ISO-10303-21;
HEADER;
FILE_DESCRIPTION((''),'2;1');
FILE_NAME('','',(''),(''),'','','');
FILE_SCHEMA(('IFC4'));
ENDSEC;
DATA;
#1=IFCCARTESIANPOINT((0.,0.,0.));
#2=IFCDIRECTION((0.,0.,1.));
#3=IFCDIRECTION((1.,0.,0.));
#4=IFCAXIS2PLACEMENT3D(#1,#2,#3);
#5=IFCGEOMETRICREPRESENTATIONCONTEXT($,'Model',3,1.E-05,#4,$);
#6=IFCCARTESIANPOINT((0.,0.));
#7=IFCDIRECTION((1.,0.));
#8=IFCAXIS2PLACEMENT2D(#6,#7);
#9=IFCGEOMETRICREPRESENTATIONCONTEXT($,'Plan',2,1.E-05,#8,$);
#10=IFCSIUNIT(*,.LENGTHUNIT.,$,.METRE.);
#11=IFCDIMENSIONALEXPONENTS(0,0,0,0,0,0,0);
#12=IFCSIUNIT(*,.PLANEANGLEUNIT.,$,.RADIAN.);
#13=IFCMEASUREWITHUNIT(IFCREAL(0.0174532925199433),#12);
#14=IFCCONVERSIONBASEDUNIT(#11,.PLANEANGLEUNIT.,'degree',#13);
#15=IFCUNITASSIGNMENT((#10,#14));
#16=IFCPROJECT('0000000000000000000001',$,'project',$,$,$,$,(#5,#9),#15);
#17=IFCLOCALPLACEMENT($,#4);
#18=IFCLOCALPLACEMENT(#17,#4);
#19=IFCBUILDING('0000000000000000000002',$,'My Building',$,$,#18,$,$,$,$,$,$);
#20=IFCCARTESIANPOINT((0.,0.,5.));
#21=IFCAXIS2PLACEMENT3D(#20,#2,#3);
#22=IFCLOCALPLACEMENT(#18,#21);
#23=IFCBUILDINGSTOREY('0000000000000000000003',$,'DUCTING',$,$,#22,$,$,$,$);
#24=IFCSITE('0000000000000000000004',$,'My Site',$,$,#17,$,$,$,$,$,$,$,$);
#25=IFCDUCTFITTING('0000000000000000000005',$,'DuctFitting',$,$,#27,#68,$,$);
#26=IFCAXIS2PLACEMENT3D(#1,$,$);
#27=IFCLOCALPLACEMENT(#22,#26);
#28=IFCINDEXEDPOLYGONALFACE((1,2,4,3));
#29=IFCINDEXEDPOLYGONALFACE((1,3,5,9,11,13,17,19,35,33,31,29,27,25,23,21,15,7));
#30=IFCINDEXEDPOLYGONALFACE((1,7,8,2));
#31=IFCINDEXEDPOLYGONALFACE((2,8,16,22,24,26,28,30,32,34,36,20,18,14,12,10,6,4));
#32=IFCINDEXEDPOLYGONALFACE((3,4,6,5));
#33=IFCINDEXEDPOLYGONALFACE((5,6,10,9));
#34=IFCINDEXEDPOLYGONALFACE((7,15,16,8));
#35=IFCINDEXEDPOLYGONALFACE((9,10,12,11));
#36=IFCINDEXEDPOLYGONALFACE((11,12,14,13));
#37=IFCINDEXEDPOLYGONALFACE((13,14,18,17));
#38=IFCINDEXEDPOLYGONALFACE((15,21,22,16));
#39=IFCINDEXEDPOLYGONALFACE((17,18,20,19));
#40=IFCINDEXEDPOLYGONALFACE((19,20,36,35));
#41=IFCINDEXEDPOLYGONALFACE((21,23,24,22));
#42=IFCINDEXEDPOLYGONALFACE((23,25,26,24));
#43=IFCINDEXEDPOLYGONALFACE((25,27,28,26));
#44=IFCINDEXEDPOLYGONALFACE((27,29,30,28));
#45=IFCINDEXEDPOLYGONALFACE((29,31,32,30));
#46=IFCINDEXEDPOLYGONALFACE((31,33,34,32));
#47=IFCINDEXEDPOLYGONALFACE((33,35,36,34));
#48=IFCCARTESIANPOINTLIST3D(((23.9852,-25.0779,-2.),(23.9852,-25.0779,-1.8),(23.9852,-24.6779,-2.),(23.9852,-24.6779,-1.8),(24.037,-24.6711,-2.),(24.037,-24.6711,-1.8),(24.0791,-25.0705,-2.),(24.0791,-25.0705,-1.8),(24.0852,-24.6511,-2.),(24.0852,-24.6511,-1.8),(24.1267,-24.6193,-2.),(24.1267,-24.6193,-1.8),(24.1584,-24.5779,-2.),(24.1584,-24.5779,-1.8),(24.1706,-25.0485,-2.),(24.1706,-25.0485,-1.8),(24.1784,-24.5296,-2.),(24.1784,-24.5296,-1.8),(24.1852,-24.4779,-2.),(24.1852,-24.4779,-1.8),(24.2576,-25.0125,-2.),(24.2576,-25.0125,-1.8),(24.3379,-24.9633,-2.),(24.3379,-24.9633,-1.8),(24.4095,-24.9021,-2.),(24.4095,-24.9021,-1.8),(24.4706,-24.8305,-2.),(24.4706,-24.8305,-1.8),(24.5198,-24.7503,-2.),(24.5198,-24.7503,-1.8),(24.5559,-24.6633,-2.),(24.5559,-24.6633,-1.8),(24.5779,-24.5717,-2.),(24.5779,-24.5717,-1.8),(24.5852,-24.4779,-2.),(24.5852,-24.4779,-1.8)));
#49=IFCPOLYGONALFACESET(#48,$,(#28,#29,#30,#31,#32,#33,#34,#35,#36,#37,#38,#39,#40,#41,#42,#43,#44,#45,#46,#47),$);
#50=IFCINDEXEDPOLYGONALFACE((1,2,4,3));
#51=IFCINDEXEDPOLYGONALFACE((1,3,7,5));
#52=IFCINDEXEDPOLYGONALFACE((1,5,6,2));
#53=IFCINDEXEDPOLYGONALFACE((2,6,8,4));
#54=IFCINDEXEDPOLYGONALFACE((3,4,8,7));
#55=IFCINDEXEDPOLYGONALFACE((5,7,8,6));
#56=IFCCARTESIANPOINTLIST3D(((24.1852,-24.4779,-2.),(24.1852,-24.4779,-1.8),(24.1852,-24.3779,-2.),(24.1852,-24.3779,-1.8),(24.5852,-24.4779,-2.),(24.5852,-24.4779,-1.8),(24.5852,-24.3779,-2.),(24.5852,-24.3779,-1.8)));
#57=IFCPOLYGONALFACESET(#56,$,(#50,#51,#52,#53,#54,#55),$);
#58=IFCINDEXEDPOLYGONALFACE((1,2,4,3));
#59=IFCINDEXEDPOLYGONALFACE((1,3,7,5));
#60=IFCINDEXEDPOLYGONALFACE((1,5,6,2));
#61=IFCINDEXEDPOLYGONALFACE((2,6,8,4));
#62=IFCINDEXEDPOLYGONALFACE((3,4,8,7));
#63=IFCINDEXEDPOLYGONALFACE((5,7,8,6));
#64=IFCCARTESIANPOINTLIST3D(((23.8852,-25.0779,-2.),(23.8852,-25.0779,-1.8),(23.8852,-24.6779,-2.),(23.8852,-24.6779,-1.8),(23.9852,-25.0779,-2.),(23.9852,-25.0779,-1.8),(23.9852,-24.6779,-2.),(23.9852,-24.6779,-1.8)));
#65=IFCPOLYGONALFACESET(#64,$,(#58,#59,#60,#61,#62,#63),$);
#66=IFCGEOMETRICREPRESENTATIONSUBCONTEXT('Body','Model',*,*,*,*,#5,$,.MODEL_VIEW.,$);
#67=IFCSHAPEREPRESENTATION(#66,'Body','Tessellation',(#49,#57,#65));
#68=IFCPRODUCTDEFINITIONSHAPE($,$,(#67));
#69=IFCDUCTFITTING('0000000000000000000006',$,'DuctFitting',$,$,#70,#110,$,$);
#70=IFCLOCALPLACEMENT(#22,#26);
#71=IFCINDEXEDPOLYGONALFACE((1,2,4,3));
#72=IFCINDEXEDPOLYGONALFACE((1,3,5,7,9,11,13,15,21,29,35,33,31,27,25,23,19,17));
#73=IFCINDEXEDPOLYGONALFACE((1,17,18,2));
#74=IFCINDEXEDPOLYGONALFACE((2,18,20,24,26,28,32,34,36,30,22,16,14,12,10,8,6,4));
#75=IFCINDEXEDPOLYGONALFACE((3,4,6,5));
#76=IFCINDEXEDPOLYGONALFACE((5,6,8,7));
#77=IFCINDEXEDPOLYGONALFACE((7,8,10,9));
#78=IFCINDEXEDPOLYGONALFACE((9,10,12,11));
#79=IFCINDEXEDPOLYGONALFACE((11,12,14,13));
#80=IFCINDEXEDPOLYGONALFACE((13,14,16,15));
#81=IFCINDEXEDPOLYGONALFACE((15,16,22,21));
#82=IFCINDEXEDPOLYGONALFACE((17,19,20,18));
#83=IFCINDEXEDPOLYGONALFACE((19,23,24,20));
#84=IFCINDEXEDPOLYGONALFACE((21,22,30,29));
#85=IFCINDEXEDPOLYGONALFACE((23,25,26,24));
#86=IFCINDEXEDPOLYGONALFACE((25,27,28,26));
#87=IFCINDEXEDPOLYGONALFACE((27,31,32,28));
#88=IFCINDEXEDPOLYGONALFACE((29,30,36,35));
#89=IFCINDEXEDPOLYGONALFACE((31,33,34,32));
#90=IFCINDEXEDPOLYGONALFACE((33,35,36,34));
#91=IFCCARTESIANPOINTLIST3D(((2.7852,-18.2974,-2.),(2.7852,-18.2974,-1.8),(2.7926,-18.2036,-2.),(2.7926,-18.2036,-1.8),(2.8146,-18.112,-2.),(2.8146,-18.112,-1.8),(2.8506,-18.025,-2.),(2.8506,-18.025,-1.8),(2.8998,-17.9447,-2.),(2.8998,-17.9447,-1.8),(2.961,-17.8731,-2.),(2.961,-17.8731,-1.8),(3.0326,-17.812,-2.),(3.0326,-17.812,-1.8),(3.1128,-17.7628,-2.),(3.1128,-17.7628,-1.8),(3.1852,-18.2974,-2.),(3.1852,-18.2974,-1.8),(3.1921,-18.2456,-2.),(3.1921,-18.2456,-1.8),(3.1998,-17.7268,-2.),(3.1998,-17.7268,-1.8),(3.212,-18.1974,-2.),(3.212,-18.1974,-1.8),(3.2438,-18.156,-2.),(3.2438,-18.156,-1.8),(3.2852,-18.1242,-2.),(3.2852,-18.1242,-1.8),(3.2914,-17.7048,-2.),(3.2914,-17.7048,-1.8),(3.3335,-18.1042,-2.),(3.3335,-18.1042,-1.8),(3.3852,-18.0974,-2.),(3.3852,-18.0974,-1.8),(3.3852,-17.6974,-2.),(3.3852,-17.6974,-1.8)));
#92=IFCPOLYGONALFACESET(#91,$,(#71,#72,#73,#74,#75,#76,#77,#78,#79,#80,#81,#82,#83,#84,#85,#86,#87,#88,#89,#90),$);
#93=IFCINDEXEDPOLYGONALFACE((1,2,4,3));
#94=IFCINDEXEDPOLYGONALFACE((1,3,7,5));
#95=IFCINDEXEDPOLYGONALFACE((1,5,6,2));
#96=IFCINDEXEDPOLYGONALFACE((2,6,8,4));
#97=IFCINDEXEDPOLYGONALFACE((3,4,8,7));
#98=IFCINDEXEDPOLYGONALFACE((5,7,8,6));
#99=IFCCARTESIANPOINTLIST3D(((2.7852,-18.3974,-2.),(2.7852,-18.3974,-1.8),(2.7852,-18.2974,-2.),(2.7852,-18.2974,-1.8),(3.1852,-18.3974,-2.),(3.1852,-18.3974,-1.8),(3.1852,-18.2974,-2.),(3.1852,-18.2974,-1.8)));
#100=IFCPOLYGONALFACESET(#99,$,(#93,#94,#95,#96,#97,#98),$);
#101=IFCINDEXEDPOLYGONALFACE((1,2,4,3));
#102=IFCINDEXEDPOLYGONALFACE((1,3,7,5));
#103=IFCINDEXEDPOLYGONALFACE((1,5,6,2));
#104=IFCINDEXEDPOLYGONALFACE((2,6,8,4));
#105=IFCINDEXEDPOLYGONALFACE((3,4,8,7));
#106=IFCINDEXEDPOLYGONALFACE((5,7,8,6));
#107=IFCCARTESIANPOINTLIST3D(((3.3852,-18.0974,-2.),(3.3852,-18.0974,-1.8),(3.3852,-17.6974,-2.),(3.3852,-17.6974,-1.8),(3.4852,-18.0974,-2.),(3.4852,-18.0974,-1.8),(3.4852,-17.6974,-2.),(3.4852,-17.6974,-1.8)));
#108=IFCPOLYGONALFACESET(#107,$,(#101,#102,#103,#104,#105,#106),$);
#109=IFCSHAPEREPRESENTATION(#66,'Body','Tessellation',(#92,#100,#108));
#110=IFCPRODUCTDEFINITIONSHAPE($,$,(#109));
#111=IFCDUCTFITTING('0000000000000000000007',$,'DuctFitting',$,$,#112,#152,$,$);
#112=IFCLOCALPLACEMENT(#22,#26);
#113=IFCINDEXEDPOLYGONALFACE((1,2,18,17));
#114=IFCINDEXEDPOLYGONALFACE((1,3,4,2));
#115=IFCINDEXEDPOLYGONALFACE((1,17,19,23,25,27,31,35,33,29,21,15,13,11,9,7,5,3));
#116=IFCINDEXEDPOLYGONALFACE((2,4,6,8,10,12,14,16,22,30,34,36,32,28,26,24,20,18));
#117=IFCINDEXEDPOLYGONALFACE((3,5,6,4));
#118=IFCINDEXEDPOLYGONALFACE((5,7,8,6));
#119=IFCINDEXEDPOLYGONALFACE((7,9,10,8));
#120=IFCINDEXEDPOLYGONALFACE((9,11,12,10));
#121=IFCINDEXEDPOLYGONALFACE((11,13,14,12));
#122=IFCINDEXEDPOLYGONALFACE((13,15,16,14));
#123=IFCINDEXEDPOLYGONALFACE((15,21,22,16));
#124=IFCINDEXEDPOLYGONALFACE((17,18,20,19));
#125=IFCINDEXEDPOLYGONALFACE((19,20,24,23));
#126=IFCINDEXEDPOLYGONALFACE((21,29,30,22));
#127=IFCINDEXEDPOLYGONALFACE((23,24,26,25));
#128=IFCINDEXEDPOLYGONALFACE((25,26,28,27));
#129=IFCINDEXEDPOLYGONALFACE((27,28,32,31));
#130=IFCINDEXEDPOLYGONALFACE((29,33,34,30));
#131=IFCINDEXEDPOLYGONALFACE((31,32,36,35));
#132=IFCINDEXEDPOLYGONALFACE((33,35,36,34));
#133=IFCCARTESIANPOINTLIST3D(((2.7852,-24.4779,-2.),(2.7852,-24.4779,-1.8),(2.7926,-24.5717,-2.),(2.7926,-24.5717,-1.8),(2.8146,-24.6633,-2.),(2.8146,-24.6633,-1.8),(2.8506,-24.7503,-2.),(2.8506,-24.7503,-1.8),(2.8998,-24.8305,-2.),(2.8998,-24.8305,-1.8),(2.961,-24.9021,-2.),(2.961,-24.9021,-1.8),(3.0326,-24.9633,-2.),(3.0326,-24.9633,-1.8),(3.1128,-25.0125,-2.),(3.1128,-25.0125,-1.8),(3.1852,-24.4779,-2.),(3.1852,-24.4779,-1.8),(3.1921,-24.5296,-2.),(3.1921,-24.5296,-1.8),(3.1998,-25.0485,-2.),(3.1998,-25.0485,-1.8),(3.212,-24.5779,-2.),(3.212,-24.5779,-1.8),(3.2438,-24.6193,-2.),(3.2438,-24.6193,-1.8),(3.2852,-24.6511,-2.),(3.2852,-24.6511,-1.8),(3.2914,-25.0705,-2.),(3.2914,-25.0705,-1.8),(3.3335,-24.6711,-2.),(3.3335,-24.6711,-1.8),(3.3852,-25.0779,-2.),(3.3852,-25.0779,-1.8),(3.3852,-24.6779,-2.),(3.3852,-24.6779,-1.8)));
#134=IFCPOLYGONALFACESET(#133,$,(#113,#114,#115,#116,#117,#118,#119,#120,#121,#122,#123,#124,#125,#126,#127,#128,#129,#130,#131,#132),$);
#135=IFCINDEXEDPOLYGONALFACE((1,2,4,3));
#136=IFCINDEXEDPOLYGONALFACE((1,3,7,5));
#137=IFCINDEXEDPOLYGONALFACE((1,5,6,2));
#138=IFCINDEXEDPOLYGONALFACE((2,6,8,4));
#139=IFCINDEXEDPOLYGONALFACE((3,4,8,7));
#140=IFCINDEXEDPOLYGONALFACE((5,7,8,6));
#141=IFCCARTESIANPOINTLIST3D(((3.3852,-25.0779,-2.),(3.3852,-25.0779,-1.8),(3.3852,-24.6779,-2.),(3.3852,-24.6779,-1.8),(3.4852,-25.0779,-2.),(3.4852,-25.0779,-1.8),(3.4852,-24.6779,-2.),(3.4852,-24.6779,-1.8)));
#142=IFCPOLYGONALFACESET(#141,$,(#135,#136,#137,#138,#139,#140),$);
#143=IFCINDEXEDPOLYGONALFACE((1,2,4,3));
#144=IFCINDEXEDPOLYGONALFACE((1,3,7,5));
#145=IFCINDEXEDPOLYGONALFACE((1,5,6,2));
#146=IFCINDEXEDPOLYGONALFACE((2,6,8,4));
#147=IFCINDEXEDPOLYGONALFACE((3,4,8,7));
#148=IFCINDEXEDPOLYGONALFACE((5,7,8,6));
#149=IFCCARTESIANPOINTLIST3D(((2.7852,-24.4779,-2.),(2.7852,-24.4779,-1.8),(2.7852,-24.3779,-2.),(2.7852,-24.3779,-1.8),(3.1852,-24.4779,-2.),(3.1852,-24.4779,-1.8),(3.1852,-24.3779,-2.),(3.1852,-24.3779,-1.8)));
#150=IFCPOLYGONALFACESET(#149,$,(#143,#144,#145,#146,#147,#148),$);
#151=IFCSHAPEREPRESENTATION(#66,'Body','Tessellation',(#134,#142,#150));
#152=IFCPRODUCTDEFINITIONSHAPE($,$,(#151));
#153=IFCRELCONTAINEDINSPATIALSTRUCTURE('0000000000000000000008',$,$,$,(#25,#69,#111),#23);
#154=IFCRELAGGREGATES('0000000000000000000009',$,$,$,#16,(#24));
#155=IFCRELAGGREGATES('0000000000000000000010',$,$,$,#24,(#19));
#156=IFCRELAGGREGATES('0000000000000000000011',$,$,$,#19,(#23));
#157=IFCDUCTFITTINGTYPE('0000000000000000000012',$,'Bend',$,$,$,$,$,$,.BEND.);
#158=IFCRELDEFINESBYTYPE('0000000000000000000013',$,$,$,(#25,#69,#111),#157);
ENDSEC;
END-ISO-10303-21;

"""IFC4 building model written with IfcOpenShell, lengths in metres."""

from ifc_helpers import new_model, entity, si_unit, converted_unit, frame, origin_with_axes, origin_2d_with_axis, place, context, subcontext, project, spatial, line, arc, indexed_curve, rectangle, outline, extrude, source, transform, mapped, type_object, type_shapes, element, save


model = new_model("IFC4")

# Units and contexts
model_context = context("Model", 3, precision=1e-05, world=origin_with_axes())
plan_context = context("Plan", 2, precision=1e-05, world=origin_2d_with_axis())
body_context = subcontext(model_context, "Body", "Model", "MODEL_VIEW")
ifc_project = project(units=[si_unit("LENGTHUNIT", "METRE"), converted_unit("PLANEANGLEUNIT", "degree", entity("IfcReal", 0.0174532925199433), si_unit("PLANEANGLEUNIT", "RADIAN"), dimensions=[0, 0, 0, 0, 0, 0, 0])], contexts=[model_context, plan_context])

# Site, building, storey
site_placement = place(None, origin_with_axes())
site = spatial("IfcSite", under=ifc_project, at=site_placement, Name="My Site")
building_placement = place(site_placement, origin_with_axes())
building = spatial("IfcBuilding", under=site, at=building_placement, Name="My Building")
storey_placement = place(building_placement, frame((0.0, 0.0, 5.0), z_axis=(0.0, 0.0, 1.0), x_axis=(1.0, 0.0, 0.0)))
storey = spatial("IfcBuildingStorey", under=building, at=storey_placement, Name="DUCTING")

# Duct fittings
duct_fitting_type = type_object("IfcDuctFittingType", Name="Bend", PredefinedType="BEND")
shared_shape = source(origin_with_axes(), body_context, "Body", "SweptSolid", [
    extrude(outline(indexed_curve([(-0.2, 0.0), (-0.2586, -0.1414), (-0.4, -0.2), (-0.4, -0.6), (0.0243, -0.4243), (0.2, 0.0)], segments=[arc(1, 2, 3), line(3, 4), arc(4, 5, 6), line(6, 1)])), frame((0.0, -0.1, -0.1), z_axis=(0.0, -1.0, 0.0), x_axis=(1.0, 0.0, 0.0)), (0.0, 0.0, -1.0), 0.2),
    extrude(rectangle(XDim=0.4, YDim=0.2), origin_with_axes(), (0.0, 0.0, -1.0), 0.1),
    extrude(rectangle(XDim=0.4, YDim=0.2), frame((-0.4, 0.0, -0.5), z_axis=(-1.0, 0.0, 0.0), x_axis=(0.0, 0.0, -1.0)), (0.0, 0.0, 1.0), 0.1),
])
type_shapes(duct_fitting_type, [shared_shape])
for number, where, z_axis, x_axis, name in (
    (1, (24.3852, -24.3779, -1.9), (0.0, 1.0, 0.0), (1.0, 0.0, 0.0), "DuctFitting"),
    (2, (2.9852, -18.3974, -1.9), (0.0, -1.0, 0.0), (-1.0, 0.0, 0.0), "DuctFitting"),
    (3, (3.4852, -24.8779, -1.9), (1.0, 0.0, 0.0), (0.0, -1.0, 0.0), "DuctFitting"),
):
    element("IfcDuctFitting", number, at=place(storey_placement, frame(where, z_axis=z_axis, x_axis=x_axis)), inside=storey, type_object=duct_fitting_type, Name=name, context=body_context, shape_type="MappedRepresentation", body=[
        mapped(shared_shape, transform((0.0, 0.0, 0.0), x_axis=(1.0, 0.0, 0.0), y_axis=(0.0, 1.0, 0.0), z_axis=(0.0, 0.0, 1.0), scale=1.0)),
    ])

save(model, "model.ifc")
